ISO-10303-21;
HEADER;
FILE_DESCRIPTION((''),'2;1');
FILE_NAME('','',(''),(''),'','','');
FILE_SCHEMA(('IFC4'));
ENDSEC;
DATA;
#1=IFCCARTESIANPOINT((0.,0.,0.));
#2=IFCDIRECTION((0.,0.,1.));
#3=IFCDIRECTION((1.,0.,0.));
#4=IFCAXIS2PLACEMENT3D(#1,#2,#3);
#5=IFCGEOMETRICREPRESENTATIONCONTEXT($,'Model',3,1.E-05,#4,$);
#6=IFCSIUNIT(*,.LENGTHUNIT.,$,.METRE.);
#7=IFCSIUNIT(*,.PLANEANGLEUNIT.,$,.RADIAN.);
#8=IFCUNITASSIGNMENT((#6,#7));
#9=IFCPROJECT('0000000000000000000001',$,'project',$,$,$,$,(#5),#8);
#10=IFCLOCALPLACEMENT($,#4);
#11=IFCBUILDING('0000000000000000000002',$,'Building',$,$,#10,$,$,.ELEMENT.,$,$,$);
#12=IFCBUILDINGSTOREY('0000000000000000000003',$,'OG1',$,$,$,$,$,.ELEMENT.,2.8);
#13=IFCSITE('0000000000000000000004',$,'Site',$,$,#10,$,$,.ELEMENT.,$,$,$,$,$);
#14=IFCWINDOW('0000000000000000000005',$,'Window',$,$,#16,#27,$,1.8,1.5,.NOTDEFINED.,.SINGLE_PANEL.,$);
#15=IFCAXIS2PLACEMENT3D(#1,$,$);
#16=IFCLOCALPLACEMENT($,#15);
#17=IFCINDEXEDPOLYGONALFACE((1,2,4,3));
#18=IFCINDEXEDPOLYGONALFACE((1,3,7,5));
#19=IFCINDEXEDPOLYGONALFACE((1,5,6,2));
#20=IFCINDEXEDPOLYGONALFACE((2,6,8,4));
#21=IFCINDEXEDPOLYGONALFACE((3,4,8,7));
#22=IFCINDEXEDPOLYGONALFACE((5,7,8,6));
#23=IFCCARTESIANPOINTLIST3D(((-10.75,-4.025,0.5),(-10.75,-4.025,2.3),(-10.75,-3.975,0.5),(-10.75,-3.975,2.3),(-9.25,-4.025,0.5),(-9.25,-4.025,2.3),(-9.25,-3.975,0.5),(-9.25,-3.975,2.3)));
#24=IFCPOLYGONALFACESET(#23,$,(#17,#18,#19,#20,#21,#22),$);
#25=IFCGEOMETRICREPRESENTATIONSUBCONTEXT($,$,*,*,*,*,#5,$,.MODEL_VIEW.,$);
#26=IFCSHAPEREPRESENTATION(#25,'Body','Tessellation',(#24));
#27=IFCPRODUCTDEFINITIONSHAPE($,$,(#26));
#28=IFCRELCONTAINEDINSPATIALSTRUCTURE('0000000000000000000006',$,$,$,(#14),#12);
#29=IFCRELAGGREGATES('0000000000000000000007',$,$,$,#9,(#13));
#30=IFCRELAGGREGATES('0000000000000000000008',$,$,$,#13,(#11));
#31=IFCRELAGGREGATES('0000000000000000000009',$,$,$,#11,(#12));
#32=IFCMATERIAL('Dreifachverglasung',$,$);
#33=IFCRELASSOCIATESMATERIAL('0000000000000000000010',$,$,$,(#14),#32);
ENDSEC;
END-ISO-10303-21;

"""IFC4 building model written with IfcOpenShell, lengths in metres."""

from ifc_helpers import new_model, si_unit, frame, origin, origin_with_axes, origin_2d, place, context, subcontext, project, spatial, rectangle, extrude, material, element, save


model = new_model("IFC4")

# Units and contexts
model_context = context("Model", 3, precision=1e-05, world=origin_with_axes())
sub_context = subcontext(model_context, None, None, "MODEL_VIEW")
ifc_project = project(units=[si_unit("LENGTHUNIT", "METRE"), si_unit("PLANEANGLEUNIT", "RADIAN")], contexts=[model_context])

# Site, building, storey
placement_1 = place(None, origin_with_axes())
site = spatial("IfcSite", under=ifc_project, at=placement_1, Name="Site", CompositionType="ELEMENT")
building = spatial("IfcBuilding", under=site, at=placement_1, Name="Building", CompositionType="ELEMENT")
storey = spatial("IfcBuildingStorey", under=building, Name="OG1", CompositionType="ELEMENT", Elevation=2.8)

# Window
ifc_material = material(Name="Dreifachverglasung")
placement_2 = place(None, origin_with_axes())
window_placement = place(placement_2, frame((-10.0, -4.0, 0.5)))
element("IfcWindow", 1, at=window_placement, inside=storey, material=ifc_material, Name="Window", OverallHeight=1.8, OverallWidth=1.5, PartitioningType="SINGLE_PANEL", PredefinedType="NOTDEFINED", context=sub_context, shape_type="SweptSolid", body=[
    extrude(rectangle(XDim=1.5, YDim=0.05, at=origin_2d()), origin(), (0.0, 0.0, 1.0), 1.8),
])

save(model, "model.ifc")
